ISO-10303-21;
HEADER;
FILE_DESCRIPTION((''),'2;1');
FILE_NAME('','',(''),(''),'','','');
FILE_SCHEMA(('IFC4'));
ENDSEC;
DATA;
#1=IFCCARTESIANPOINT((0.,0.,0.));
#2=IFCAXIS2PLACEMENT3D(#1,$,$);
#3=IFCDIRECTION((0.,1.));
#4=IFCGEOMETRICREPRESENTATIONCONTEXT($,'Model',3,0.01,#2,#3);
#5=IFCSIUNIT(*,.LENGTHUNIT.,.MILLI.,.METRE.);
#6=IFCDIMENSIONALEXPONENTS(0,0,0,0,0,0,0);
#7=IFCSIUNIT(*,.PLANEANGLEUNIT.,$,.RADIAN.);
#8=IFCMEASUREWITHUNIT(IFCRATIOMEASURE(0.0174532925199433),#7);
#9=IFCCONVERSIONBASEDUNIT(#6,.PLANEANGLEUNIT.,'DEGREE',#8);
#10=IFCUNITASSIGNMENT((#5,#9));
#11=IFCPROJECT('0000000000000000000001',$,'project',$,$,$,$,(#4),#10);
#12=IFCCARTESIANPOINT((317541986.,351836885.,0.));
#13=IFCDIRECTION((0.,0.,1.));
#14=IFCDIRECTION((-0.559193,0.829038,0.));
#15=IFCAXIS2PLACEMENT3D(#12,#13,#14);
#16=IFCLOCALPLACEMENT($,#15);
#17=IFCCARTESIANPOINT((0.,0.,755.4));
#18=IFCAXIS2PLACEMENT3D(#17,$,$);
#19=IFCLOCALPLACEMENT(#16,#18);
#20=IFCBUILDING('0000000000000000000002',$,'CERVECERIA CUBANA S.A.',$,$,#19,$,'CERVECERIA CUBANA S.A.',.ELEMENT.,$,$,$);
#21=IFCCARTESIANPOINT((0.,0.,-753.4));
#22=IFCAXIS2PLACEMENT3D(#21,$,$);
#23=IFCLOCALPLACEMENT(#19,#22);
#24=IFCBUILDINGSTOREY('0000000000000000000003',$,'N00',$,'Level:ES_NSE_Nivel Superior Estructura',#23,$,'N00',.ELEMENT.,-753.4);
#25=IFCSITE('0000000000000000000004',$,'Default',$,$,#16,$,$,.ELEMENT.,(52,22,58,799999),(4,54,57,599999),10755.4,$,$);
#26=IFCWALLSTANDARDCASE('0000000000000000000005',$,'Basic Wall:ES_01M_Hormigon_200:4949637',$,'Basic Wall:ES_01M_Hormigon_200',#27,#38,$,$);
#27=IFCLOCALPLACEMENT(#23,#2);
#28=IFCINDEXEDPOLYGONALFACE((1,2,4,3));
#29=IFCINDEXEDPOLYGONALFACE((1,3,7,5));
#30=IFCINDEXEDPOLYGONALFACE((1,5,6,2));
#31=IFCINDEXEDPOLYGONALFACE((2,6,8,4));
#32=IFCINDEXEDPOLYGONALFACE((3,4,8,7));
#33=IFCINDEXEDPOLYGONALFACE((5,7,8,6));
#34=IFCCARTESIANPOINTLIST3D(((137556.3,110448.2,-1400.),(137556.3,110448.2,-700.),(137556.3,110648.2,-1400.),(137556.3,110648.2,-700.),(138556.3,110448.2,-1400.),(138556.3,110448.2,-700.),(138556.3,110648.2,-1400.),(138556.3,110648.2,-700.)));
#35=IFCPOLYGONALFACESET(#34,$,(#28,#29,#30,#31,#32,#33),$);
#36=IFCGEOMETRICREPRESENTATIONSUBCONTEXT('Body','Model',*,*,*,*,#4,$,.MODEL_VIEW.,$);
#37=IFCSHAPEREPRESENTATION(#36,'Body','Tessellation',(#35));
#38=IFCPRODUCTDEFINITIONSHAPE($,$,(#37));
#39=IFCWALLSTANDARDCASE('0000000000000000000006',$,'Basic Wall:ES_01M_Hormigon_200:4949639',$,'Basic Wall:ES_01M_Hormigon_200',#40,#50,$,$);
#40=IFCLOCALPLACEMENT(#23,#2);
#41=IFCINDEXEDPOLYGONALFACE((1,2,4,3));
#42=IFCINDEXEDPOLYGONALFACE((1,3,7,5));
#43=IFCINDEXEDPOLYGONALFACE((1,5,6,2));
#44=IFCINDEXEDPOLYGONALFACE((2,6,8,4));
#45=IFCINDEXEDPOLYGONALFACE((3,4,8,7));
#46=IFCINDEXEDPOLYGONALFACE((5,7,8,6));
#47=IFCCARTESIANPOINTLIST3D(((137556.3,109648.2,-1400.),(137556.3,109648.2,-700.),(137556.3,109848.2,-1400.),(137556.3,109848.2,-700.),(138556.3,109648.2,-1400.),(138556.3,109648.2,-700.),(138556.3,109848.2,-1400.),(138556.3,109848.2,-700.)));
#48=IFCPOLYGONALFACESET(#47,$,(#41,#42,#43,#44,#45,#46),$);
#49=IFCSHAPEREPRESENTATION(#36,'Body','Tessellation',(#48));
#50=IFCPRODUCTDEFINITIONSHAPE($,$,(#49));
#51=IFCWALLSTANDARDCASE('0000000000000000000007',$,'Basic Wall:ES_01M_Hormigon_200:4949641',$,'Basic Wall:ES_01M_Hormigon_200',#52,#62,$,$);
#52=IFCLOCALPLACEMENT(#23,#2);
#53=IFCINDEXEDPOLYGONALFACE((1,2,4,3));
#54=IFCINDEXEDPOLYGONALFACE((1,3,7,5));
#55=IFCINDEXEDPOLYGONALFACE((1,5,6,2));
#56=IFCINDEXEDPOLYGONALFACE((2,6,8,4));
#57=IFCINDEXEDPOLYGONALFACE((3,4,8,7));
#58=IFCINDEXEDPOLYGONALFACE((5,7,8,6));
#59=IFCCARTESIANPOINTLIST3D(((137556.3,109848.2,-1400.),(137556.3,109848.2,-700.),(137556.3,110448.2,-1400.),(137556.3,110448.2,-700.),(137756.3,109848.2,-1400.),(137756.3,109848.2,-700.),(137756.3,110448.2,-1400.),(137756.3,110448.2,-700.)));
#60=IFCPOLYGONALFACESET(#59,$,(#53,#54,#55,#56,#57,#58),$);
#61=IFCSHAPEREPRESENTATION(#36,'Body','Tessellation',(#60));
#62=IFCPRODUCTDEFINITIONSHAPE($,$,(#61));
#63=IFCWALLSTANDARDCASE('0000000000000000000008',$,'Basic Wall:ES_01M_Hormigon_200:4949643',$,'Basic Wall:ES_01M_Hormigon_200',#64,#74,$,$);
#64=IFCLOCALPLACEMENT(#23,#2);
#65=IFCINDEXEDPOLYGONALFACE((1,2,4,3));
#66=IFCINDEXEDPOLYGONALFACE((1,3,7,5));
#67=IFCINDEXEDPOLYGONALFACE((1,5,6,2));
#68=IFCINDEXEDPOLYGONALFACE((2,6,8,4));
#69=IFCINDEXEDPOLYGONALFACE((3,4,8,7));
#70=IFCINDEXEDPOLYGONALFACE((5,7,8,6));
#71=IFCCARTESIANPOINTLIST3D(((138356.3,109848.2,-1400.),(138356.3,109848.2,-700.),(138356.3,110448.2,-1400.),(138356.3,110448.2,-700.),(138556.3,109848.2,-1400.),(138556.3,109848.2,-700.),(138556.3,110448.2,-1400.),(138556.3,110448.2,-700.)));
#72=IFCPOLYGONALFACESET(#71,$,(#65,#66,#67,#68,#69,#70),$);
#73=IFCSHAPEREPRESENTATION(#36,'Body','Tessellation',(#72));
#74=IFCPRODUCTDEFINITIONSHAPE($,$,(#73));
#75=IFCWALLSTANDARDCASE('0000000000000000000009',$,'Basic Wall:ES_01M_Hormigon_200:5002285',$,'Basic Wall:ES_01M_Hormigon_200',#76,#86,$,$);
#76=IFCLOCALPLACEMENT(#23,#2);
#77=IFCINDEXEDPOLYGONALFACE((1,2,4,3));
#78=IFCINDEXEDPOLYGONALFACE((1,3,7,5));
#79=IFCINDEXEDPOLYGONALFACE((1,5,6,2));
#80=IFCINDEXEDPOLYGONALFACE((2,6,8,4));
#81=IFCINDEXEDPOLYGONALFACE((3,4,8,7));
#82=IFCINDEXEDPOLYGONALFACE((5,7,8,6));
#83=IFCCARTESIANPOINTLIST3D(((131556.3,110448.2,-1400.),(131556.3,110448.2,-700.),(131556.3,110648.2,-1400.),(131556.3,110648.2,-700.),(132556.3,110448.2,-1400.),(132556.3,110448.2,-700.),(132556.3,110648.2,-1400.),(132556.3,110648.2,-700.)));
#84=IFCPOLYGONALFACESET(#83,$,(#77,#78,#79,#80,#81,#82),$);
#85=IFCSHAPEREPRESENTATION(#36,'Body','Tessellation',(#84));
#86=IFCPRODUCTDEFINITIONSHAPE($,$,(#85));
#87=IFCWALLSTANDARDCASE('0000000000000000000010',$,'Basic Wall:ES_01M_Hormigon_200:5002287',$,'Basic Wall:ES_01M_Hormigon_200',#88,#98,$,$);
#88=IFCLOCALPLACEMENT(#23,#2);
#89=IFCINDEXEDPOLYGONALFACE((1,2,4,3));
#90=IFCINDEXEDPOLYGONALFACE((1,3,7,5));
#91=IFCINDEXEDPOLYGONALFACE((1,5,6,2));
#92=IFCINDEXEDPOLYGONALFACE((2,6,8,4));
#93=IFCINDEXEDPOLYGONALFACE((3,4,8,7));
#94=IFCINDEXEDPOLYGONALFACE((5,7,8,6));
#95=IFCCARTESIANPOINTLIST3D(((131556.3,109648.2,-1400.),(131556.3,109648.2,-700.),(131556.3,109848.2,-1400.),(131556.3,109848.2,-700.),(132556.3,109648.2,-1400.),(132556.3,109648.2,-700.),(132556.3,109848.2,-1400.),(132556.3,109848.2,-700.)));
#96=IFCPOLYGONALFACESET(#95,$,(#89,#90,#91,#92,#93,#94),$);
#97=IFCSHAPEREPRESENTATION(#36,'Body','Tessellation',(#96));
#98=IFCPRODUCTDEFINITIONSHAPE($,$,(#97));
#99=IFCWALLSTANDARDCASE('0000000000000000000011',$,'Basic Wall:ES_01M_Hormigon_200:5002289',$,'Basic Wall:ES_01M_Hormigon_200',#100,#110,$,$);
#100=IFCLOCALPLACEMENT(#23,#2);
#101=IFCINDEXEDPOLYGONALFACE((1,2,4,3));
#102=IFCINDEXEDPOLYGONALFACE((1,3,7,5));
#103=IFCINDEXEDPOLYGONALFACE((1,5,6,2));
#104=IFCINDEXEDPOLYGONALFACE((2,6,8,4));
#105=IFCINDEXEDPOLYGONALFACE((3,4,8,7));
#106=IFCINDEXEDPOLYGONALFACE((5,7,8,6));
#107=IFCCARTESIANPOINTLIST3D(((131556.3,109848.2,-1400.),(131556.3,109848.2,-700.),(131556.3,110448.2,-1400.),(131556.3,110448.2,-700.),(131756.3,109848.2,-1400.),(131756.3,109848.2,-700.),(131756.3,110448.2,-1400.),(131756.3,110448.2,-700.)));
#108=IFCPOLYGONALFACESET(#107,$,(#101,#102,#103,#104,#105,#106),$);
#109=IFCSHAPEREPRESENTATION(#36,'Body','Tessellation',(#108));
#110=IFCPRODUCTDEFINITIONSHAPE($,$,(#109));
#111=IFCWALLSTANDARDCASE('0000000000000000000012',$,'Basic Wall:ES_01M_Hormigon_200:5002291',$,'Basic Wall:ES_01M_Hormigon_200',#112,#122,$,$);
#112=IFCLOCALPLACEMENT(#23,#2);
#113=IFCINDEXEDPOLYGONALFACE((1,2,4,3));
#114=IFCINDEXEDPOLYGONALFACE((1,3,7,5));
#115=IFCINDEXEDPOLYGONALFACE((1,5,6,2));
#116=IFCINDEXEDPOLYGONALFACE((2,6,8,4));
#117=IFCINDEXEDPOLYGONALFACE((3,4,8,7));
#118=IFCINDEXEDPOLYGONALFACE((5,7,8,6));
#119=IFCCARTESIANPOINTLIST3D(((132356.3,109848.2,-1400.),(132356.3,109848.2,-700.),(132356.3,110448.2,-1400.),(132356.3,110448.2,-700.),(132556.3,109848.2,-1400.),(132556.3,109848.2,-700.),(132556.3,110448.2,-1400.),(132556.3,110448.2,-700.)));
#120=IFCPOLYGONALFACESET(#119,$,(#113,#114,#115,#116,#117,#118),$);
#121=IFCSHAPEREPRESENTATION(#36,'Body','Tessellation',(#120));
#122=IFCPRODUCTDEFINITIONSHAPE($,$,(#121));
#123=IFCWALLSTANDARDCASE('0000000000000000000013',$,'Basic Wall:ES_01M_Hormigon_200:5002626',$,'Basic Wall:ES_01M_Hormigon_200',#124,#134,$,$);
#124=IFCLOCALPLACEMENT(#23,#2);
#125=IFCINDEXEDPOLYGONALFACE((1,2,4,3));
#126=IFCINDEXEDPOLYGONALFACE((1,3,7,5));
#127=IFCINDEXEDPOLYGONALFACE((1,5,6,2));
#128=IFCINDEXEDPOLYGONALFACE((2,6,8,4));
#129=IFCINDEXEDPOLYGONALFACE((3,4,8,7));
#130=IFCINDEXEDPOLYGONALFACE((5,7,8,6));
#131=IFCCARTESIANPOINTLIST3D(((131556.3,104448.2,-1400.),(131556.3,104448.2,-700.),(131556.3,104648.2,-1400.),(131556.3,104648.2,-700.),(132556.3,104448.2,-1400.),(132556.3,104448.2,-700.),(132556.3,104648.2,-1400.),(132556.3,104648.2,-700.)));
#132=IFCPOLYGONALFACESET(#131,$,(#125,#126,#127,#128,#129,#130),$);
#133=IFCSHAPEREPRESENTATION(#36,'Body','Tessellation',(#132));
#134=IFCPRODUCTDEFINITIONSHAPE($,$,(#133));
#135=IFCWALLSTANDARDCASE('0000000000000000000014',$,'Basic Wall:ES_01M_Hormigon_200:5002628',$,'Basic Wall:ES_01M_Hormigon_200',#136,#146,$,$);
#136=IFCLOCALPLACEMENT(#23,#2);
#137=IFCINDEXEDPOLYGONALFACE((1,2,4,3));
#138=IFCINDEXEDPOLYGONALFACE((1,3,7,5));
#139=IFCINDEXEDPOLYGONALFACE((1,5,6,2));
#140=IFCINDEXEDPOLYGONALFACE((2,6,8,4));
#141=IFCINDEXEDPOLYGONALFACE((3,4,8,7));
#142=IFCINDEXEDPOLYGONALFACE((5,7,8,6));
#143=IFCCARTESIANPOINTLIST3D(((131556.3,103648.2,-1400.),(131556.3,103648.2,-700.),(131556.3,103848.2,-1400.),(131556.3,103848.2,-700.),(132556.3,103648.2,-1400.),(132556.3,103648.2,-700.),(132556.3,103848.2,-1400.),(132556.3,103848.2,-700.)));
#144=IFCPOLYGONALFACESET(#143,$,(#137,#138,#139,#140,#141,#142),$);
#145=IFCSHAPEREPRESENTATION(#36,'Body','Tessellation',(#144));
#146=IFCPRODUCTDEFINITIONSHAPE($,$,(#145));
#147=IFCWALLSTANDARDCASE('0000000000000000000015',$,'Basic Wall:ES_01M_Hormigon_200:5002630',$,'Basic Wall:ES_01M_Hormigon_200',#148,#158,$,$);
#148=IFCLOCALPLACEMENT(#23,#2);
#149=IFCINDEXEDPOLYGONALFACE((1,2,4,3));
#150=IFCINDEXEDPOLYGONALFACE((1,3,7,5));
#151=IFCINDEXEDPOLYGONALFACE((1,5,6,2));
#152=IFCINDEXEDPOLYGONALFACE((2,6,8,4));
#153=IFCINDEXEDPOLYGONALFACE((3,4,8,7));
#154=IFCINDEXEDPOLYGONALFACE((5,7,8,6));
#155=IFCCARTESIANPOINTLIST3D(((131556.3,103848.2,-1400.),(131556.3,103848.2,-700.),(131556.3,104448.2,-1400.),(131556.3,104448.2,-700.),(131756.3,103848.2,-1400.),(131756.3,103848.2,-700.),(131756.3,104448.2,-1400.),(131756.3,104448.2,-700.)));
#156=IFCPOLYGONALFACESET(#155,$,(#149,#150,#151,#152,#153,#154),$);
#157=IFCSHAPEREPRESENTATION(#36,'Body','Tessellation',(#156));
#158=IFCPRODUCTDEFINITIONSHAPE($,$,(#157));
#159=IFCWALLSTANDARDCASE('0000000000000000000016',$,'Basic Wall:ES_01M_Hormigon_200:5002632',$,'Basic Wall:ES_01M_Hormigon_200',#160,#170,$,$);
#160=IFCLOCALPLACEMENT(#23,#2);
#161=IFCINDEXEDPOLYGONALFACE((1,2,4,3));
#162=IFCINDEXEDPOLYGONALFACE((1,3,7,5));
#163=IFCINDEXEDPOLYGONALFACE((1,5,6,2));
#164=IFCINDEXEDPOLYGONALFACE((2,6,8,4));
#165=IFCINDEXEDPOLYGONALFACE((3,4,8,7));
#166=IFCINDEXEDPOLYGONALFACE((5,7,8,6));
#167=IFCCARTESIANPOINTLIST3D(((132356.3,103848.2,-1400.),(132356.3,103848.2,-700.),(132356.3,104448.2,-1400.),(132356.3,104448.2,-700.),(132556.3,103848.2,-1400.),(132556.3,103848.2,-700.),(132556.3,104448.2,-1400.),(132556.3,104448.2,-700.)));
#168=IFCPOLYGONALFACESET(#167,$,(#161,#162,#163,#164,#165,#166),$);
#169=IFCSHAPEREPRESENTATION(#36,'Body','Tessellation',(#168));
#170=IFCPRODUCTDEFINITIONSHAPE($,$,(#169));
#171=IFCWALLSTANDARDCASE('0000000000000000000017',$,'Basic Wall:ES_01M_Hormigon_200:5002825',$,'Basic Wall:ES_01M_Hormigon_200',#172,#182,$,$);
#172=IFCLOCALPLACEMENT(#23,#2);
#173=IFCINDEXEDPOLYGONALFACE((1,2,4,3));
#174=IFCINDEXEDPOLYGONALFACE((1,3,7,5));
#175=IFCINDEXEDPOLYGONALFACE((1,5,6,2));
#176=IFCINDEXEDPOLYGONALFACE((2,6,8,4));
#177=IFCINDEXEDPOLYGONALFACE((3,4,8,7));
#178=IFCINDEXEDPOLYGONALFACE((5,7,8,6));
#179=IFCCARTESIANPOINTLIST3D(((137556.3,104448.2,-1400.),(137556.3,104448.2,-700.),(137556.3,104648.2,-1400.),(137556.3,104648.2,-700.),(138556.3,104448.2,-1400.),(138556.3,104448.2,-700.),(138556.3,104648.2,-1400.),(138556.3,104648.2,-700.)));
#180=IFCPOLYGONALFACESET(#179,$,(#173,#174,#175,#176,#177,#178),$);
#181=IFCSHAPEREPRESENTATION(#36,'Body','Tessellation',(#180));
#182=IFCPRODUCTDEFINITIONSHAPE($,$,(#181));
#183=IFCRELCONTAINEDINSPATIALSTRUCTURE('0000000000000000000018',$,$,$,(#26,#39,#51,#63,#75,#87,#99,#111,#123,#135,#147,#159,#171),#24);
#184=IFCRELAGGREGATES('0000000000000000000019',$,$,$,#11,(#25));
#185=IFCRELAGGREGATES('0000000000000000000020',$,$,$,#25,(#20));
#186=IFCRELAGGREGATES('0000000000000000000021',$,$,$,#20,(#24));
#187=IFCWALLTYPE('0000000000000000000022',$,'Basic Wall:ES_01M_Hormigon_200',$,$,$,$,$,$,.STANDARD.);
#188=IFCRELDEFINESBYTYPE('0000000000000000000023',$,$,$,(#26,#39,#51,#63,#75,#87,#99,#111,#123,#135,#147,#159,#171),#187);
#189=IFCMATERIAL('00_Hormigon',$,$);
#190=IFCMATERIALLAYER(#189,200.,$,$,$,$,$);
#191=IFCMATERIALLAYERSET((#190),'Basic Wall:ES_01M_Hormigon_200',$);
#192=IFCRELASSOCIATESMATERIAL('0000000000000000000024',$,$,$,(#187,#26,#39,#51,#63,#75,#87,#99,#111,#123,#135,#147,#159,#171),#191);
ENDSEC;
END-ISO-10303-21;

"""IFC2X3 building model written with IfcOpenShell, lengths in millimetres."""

from ifc_helpers import new_model, entity, si_unit, converted_unit, direction, frame, frame_2d, origin, place, context, subcontext, project, spatial, rectangle, extrude, material, layer, layer_set, layer_usage, type_object, element, save


model = new_model("IFC2X3")

# Units and contexts
model_context = context("Model", 3, precision=0.01, world=origin(), true_north=direction((0.0, 1.0)))
body_context = subcontext(model_context, "Body", "Model", "MODEL_VIEW")
ifc_project = project(units=[si_unit("LENGTHUNIT", "METRE", prefix="MILLI"), converted_unit("PLANEANGLEUNIT", "DEGREE", entity("IfcRatioMeasure", 0.0174532925199433), si_unit("PLANEANGLEUNIT", "RADIAN"), dimensions=[0, 0, 0, 0, 0, 0, 0])], contexts=[model_context])

# Site, building, storey
site_placement = place(None, frame((317541986.0, 351836885.0, 0.0), z_axis=(0.0, 0.0, 1.0), x_axis=(-0.559193, 0.829038, 0.0)))
site = spatial("IfcSite", under=ifc_project, at=site_placement, Name="Default", CompositionType="ELEMENT", RefLatitude=(52, 22, 58, 799999), RefLongitude=(4, 54, 57, 599999), RefElevation=10755.4)
building_placement = place(site_placement, frame((0.0, 0.0, 755.4)))
building = spatial("IfcBuilding", under=site, at=building_placement, Name="CERVECERIA CUBANA S.A.", LongName="CERVECERIA CUBANA S.A.", CompositionType="ELEMENT")
storey_placement = place(building_placement, frame((0.0, 0.0, -753.4)))
storey = spatial("IfcBuildingStorey", under=building, at=storey_placement, Name="N00", ObjectType="Level:ES_NSE_Nivel Superior Estructura", LongName="N00", CompositionType="ELEMENT", Elevation=-753.4)

# Shared definitions
ifc_material = material(Name="00_Hormigon")

# Walls
ifc_layer_1 = layer(ifc_material, 200.0)
ifc_layer_set_1 = layer_set([ifc_layer_1], Name="Basic Wall:ES_01M_Hormigon_200")
ifc_layer_usage_1 = layer_usage(ifc_layer_set_1, "AXIS2", "NEGATIVE", 100.0)
wall_type = type_object("IfcWallType", Name="Basic Wall:ES_01M_Hormigon_200", PredefinedType="STANDARD", material=ifc_layer_set_1)
wall_1_placement = place(storey_placement, frame((137556.3, 110548.2, -1400.0)))
element("IfcWallStandardCase", 1, at=wall_1_placement, inside=storey, type_object=wall_type, material=ifc_layer_usage_1, Name="Basic Wall:ES_01M_Hormigon_200:4949637", ObjectType="Basic Wall:ES_01M_Hormigon_200", context=body_context, shape_type="SweptSolid", body=[
    extrude(rectangle(XDim=1000.0, YDim=200.0, at=frame_2d((500.0, 0.0), x_axis=(-1.0, 0.0))), origin(), (0.0, 0.0, 1.0), 700.0),
])
ifc_layer_usage_2 = layer_usage(ifc_layer_set_1, "AXIS2", "POSITIVE", -100.0)
wall_2_placement = place(storey_placement, frame((137556.3, 109748.2, -1400.0)))
element("IfcWallStandardCase", 2, at=wall_2_placement, inside=storey, type_object=wall_type, material=ifc_layer_usage_2, Name="Basic Wall:ES_01M_Hormigon_200:4949639", ObjectType="Basic Wall:ES_01M_Hormigon_200", context=body_context, shape_type="SweptSolid", body=[
    extrude(rectangle(XDim=1000.0, YDim=200.0, at=frame_2d((500.0, 0.0), x_axis=(-1.0, 0.0))), origin(), (0.0, 0.0, 1.0), 700.0),
])
ifc_layer_usage_3 = layer_usage(ifc_layer_set_1, "AXIS2", "POSITIVE", -100.0)
wall_3_placement = place(storey_placement, frame((137656.3, 110448.2, -1400.0), z_axis=(0.0, 0.0, 1.0), x_axis=(0.0, -1.0, 0.0)))
element("IfcWallStandardCase", 3, at=wall_3_placement, inside=storey, type_object=wall_type, material=ifc_layer_usage_3, Name="Basic Wall:ES_01M_Hormigon_200:4949641", ObjectType="Basic Wall:ES_01M_Hormigon_200", context=body_context, shape_type="SweptSolid", body=[
    extrude(rectangle(XDim=600.0, YDim=200.0, at=frame_2d((300.0, 0.0), x_axis=(-1.0, 0.0))), origin(), (0.0, 0.0, 1.0), 700.0),
])
ifc_layer_usage_4 = layer_usage(ifc_layer_set_1, "AXIS2", "NEGATIVE", 100.0)
wall_4_placement = place(storey_placement, frame((138456.3, 110448.2, -1400.0), z_axis=(0.0, 0.0, 1.0), x_axis=(0.0, -1.0, 0.0)))
element("IfcWallStandardCase", 4, at=wall_4_placement, inside=storey, type_object=wall_type, material=ifc_layer_usage_4, Name="Basic Wall:ES_01M_Hormigon_200:4949643", ObjectType="Basic Wall:ES_01M_Hormigon_200", context=body_context, shape_type="SweptSolid", body=[
    extrude(rectangle(XDim=600.0, YDim=200.0, at=frame_2d((300.0, 0.0), x_axis=(-1.0, 0.0))), origin(), (0.0, 0.0, 1.0), 700.0),
])
ifc_layer_usage_5 = layer_usage(ifc_layer_set_1, "AXIS2", "NEGATIVE", 100.0)
wall_5_placement = place(storey_placement, frame((131556.3, 110548.2, -1400.0)))
element("IfcWallStandardCase", 5, at=wall_5_placement, inside=storey, type_object=wall_type, material=ifc_layer_usage_5, Name="Basic Wall:ES_01M_Hormigon_200:5002285", ObjectType="Basic Wall:ES_01M_Hormigon_200", context=body_context, shape_type="SweptSolid", body=[
    extrude(rectangle(XDim=1000.0, YDim=200.0, at=frame_2d((500.0, 0.0), x_axis=(-1.0, 0.0))), origin(), (0.0, 0.0, 1.0), 700.0),
])
ifc_layer_usage_6 = layer_usage(ifc_layer_set_1, "AXIS2", "POSITIVE", -100.0)
wall_6_placement = place(storey_placement, frame((131556.3, 109748.2, -1400.0)))
element("IfcWallStandardCase", 6, at=wall_6_placement, inside=storey, type_object=wall_type, material=ifc_layer_usage_6, Name="Basic Wall:ES_01M_Hormigon_200:5002287", ObjectType="Basic Wall:ES_01M_Hormigon_200", context=body_context, shape_type="SweptSolid", body=[
    extrude(rectangle(XDim=1000.0, YDim=200.0, at=frame_2d((500.0, 0.0), x_axis=(-1.0, 0.0))), origin(), (0.0, 0.0, 1.0), 700.0),
])
ifc_layer_usage_7 = layer_usage(ifc_layer_set_1, "AXIS2", "POSITIVE", -100.0)
wall_7_placement = place(storey_placement, frame((131656.3, 110448.2, -1400.0), z_axis=(0.0, 0.0, 1.0), x_axis=(0.0, -1.0, 0.0)))
element("IfcWallStandardCase", 7, at=wall_7_placement, inside=storey, type_object=wall_type, material=ifc_layer_usage_7, Name="Basic Wall:ES_01M_Hormigon_200:5002289", ObjectType="Basic Wall:ES_01M_Hormigon_200", context=body_context, shape_type="SweptSolid", body=[
    extrude(rectangle(XDim=600.0, YDim=200.0, at=frame_2d((300.0, 0.0), x_axis=(-1.0, 0.0))), origin(), (0.0, 0.0, 1.0), 700.0),
])
ifc_layer_usage_8 = layer_usage(ifc_layer_set_1, "AXIS2", "NEGATIVE", 100.0)
wall_8_placement = place(storey_placement, frame((132456.3, 110448.2, -1400.0), z_axis=(0.0, 0.0, 1.0), x_axis=(0.0, -1.0, 0.0)))
element("IfcWallStandardCase", 8, at=wall_8_placement, inside=storey, type_object=wall_type, material=ifc_layer_usage_8, Name="Basic Wall:ES_01M_Hormigon_200:5002291", ObjectType="Basic Wall:ES_01M_Hormigon_200", context=body_context, shape_type="SweptSolid", body=[
    extrude(rectangle(XDim=600.0, YDim=200.0, at=frame_2d((300.0, 0.0), x_axis=(-1.0, 0.0))), origin(), (0.0, 0.0, 1.0), 700.0),
])
ifc_layer_usage_9 = layer_usage(ifc_layer_set_1, "AXIS2", "NEGATIVE", 100.0)
wall_9_placement = place(storey_placement, frame((131556.3, 104548.2, -1400.0)))
element("IfcWallStandardCase", 9, at=wall_9_placement, inside=storey, type_object=wall_type, material=ifc_layer_usage_9, Name="Basic Wall:ES_01M_Hormigon_200:5002626", ObjectType="Basic Wall:ES_01M_Hormigon_200", context=body_context, shape_type="SweptSolid", body=[
    extrude(rectangle(XDim=1000.0, YDim=200.0, at=frame_2d((500.0, 0.0), x_axis=(-1.0, 0.0))), origin(), (0.0, 0.0, 1.0), 700.0),
])
ifc_layer_usage_10 = layer_usage(ifc_layer_set_1, "AXIS2", "POSITIVE", -100.0)
wall_10_placement = place(storey_placement, frame((131556.3, 103748.2, -1400.0)))
element("IfcWallStandardCase", 10, at=wall_10_placement, inside=storey, type_object=wall_type, material=ifc_layer_usage_10, Name="Basic Wall:ES_01M_Hormigon_200:5002628", ObjectType="Basic Wall:ES_01M_Hormigon_200", context=body_context, shape_type="SweptSolid", body=[
    extrude(rectangle(XDim=1000.0, YDim=200.0, at=frame_2d((500.0, 0.0), x_axis=(-1.0, 0.0))), origin(), (0.0, 0.0, 1.0), 700.0),
])
ifc_layer_usage_11 = layer_usage(ifc_layer_set_1, "AXIS2", "POSITIVE", -100.0)
wall_11_placement = place(storey_placement, frame((131656.3, 104448.2, -1400.0), z_axis=(0.0, 0.0, 1.0), x_axis=(0.0, -1.0, 0.0)))
element("IfcWallStandardCase", 11, at=wall_11_placement, inside=storey, type_object=wall_type, material=ifc_layer_usage_11, Name="Basic Wall:ES_01M_Hormigon_200:5002630", ObjectType="Basic Wall:ES_01M_Hormigon_200", context=body_context, shape_type="SweptSolid", body=[
    extrude(rectangle(XDim=600.0, YDim=200.0, at=frame_2d((300.0, 0.0), x_axis=(-1.0, 0.0))), origin(), (0.0, 0.0, 1.0), 700.0),
])
ifc_layer_usage_12 = layer_usage(ifc_layer_set_1, "AXIS2", "NEGATIVE", 100.0)
wall_12_placement = place(storey_placement, frame((132456.3, 104448.2, -1400.0), z_axis=(0.0, 0.0, 1.0), x_axis=(0.0, -1.0, 0.0)))
element("IfcWallStandardCase", 12, at=wall_12_placement, inside=storey, type_object=wall_type, material=ifc_layer_usage_12, Name="Basic Wall:ES_01M_Hormigon_200:5002632", ObjectType="Basic Wall:ES_01M_Hormigon_200", context=body_context, shape_type="SweptSolid", body=[
    extrude(rectangle(XDim=600.0, YDim=200.0, at=frame_2d((300.0, 0.0), x_axis=(-1.0, 0.0))), origin(), (0.0, 0.0, 1.0), 700.0),
])
ifc_layer_usage_13 = layer_usage(ifc_layer_set_1, "AXIS2", "NEGATIVE", 100.0)
wall_13_placement = place(storey_placement, frame((137556.3, 104548.2, -1400.0)))
element("IfcWallStandardCase", 13, at=wall_13_placement, inside=storey, type_object=wall_type, material=ifc_layer_usage_13, Name="Basic Wall:ES_01M_Hormigon_200:5002825", ObjectType="Basic Wall:ES_01M_Hormigon_200", context=body_context, shape_type="SweptSolid", body=[
    extrude(rectangle(XDim=1000.0, YDim=200.0, at=frame_2d((500.0, 0.0), x_axis=(-1.0, 0.0))), origin(), (0.0, 0.0, 1.0), 700.0),
])

save(model, "model.ifc")
